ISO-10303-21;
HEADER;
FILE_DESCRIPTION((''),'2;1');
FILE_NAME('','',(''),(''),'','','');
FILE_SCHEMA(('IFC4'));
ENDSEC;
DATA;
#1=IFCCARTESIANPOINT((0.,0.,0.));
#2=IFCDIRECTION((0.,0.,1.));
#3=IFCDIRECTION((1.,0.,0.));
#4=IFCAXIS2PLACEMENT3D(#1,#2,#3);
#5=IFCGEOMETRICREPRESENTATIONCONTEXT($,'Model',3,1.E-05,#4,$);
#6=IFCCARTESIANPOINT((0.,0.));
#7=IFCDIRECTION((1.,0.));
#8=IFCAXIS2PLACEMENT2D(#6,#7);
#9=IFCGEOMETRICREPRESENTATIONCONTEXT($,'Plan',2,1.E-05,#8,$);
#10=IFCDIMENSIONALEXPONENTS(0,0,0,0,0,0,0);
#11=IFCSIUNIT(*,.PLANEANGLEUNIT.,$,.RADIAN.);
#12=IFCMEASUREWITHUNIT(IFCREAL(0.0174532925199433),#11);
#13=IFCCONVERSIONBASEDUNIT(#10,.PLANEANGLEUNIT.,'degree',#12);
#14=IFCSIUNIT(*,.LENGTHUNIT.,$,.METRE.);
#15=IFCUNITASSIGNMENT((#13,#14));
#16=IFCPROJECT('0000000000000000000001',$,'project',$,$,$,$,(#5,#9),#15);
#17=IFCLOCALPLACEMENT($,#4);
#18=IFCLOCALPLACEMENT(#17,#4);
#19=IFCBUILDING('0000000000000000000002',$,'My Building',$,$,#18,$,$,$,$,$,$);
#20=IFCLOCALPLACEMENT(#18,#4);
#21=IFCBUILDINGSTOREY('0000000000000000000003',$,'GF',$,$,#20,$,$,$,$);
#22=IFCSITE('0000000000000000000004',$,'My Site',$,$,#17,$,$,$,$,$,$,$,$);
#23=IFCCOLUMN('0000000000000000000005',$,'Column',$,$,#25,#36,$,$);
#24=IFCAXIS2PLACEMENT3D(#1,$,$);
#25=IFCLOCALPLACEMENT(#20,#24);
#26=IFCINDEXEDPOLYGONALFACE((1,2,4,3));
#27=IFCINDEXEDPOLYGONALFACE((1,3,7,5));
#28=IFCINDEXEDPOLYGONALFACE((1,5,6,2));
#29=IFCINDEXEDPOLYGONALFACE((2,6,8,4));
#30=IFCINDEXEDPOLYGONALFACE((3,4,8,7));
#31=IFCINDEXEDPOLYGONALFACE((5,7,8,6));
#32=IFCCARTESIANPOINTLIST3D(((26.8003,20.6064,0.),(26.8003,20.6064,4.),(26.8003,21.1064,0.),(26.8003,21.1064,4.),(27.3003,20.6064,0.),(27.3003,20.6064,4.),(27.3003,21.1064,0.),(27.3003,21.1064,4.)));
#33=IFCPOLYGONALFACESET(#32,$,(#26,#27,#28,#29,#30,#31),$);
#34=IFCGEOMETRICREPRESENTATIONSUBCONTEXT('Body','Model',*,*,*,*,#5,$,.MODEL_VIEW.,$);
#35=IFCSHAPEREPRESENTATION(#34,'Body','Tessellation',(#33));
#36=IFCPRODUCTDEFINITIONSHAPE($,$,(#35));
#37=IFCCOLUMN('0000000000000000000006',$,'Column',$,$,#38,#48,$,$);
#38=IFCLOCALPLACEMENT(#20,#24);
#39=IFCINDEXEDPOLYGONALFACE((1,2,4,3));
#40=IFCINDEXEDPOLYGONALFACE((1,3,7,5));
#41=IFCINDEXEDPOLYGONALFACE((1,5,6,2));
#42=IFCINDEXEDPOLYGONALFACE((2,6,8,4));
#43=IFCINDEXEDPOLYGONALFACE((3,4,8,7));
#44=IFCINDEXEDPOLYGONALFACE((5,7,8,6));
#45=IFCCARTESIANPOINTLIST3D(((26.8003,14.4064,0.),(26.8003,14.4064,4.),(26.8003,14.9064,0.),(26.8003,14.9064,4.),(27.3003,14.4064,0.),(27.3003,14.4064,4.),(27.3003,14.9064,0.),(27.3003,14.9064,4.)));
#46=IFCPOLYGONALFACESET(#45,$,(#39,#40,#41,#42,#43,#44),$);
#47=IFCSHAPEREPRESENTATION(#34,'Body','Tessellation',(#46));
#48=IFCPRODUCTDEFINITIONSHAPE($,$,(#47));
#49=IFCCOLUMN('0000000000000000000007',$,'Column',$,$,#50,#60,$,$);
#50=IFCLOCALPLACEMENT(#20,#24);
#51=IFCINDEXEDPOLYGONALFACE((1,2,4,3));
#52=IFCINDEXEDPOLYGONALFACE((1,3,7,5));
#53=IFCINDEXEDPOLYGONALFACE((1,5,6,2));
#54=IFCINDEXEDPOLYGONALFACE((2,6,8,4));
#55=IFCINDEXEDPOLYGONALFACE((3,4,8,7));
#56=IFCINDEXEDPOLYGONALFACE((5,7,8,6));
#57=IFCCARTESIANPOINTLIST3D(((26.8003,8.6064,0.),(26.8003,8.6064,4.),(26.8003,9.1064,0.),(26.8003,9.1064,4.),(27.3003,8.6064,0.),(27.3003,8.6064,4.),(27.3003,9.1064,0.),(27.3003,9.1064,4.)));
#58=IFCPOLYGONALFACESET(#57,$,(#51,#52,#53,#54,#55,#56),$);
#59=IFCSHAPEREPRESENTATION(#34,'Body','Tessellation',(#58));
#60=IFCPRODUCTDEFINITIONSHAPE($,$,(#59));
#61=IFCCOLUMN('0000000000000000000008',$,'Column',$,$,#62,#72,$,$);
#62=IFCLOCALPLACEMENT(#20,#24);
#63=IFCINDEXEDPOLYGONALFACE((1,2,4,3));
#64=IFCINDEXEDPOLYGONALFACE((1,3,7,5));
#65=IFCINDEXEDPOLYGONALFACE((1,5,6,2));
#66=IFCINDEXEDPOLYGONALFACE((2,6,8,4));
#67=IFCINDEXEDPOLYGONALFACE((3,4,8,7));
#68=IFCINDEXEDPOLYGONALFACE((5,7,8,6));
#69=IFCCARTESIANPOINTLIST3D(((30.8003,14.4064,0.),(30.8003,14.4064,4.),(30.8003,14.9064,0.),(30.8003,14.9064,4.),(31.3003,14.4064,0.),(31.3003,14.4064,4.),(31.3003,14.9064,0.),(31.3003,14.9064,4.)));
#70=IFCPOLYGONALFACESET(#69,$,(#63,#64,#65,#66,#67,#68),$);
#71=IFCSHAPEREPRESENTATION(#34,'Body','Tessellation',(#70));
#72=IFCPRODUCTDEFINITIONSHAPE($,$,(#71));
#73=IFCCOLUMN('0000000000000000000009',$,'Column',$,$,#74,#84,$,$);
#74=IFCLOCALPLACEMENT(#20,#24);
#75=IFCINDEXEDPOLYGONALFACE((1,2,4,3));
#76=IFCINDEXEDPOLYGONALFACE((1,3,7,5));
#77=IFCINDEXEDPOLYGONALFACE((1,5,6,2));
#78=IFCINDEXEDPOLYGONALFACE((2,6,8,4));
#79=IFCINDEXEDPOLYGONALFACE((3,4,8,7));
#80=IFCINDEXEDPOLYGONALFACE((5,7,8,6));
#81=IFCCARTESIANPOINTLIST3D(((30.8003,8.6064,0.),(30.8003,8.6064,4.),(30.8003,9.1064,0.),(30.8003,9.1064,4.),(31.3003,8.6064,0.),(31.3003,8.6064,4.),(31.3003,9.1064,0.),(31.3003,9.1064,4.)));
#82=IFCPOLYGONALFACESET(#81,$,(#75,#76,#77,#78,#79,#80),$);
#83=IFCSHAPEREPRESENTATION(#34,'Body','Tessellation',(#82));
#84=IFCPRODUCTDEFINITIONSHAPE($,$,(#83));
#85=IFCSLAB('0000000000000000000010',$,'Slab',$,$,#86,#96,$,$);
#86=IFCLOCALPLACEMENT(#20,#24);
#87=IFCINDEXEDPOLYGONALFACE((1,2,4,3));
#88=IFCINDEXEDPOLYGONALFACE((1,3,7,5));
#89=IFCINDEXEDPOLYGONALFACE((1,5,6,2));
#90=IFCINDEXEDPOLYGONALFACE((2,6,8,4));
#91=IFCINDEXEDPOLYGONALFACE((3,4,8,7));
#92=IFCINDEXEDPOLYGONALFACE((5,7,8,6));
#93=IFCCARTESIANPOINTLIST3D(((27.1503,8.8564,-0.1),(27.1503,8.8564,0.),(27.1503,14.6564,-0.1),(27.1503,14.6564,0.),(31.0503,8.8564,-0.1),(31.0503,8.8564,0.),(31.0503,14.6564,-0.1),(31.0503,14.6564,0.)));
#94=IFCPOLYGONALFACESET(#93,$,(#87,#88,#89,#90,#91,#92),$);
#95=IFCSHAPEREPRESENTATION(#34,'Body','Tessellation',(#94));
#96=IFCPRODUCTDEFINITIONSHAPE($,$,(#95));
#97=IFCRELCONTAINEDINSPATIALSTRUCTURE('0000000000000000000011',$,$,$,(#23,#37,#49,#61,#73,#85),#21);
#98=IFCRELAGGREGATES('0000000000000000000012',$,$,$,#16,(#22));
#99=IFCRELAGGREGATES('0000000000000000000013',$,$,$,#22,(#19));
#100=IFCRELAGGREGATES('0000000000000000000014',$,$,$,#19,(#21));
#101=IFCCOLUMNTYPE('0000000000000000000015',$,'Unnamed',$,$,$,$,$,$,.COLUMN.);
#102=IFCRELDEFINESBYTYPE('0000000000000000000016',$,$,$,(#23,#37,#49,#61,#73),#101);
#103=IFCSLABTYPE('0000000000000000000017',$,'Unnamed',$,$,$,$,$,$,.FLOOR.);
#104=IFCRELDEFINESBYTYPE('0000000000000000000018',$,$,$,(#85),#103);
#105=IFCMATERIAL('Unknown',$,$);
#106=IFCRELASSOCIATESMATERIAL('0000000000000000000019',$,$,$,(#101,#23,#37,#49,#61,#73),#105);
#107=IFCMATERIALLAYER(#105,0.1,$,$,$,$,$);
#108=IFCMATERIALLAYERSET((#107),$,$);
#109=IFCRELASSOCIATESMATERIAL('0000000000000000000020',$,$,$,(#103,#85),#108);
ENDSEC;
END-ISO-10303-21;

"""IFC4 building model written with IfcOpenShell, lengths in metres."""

from ifc_helpers import new_model, entity, si_unit, converted_unit, frame, origin_with_axes, origin_2d_with_axis, place, context, subcontext, project, spatial, indexed_curve, rectangle, outline, extrude, material, layer, layer_set, layer_usage, material_profile, profile_set, profile_usage, type_object, element, save


model = new_model("IFC4")

# Units and contexts
model_context = context("Model", 3, precision=1e-05, world=origin_with_axes())
plan_context = context("Plan", 2, precision=1e-05, world=origin_2d_with_axis())
body_context_1 = subcontext(model_context, "Body", "Model", "MODEL_VIEW")
ifc_project = project(units=[converted_unit("PLANEANGLEUNIT", "degree", entity("IfcReal", 0.0174532925199433), si_unit("PLANEANGLEUNIT", "RADIAN"), dimensions=[0, 0, 0, 0, 0, 0, 0]), si_unit("LENGTHUNIT", "METRE")], contexts=[model_context, plan_context])

# Site, building, storey
site_placement = place(None, origin_with_axes())
site = spatial("IfcSite", under=ifc_project, at=site_placement, Name="My Site")
building_placement = place(site_placement, origin_with_axes())
building = spatial("IfcBuilding", under=site, at=building_placement, Name="My Building")
storey_placement = place(building_placement, origin_with_axes())
storey = spatial("IfcBuildingStorey", under=building, at=storey_placement, Name="GF")

# Columns
ifc_material = material(Name="Unknown")
ifc_material_profile_1 = material_profile(ifc_material, rectangle(XDim=0.5, YDim=0.5))
ifc_profile_set_1 = profile_set([ifc_material_profile_1])
ifc_profile_usage_1 = profile_usage(ifc_profile_set_1, cardinal=5)
column_type = type_object("IfcColumnType", Name="Unnamed", PredefinedType="COLUMN", material=ifc_profile_set_1)
column_1_placement = place(storey_placement, frame((27.0503, 20.8564, 0.0), z_axis=(0.0, 0.0, 1.0), x_axis=(1.0, 0.0, 0.0)))
element("IfcColumn", 1, at=column_1_placement, inside=storey, type_object=column_type, material=ifc_profile_usage_1, Name="Column", context=body_context_1, shape_type="SweptSolid", body=[
    extrude(rectangle(XDim=0.5, YDim=0.5), origin_with_axes(), (0.0, 0.0, 1.0), 4.0),
])
ifc_profile_usage_2 = profile_usage(ifc_profile_set_1, cardinal=5)
column_2_placement = place(storey_placement, frame((27.0503, 14.6564, 0.0), z_axis=(0.0, 0.0, 1.0), x_axis=(1.0, 0.0, 0.0)))
element("IfcColumn", 2, at=column_2_placement, inside=storey, type_object=column_type, material=ifc_profile_usage_2, Name="Column", context=body_context_1, shape_type="SweptSolid", body=[
    extrude(rectangle(XDim=0.5, YDim=0.5), origin_with_axes(), (0.0, 0.0, 1.0), 4.0),
])
ifc_profile_usage_3 = profile_usage(ifc_profile_set_1, cardinal=5)
column_3_placement = place(storey_placement, frame((27.0503, 8.8564, 0.0), z_axis=(0.0, 0.0, 1.0), x_axis=(1.0, 0.0, 0.0)))
element("IfcColumn", 3, at=column_3_placement, inside=storey, type_object=column_type, material=ifc_profile_usage_3, Name="Column", context=body_context_1, shape_type="SweptSolid", body=[
    extrude(rectangle(XDim=0.5, YDim=0.5), origin_with_axes(), (0.0, 0.0, 1.0), 4.0),
])
ifc_profile_usage_4 = profile_usage(ifc_profile_set_1, cardinal=5)
column_4_placement = place(storey_placement, frame((31.0503, 14.6564, 0.0), z_axis=(0.0, 0.0, 1.0), x_axis=(1.0, 0.0, 0.0)))
element("IfcColumn", 4, at=column_4_placement, inside=storey, type_object=column_type, material=ifc_profile_usage_4, Name="Column", context=body_context_1, shape_type="SweptSolid", body=[
    extrude(rectangle(XDim=0.5, YDim=0.5), origin_with_axes(), (0.0, 0.0, 1.0), 4.0),
])
ifc_profile_usage_5 = profile_usage(ifc_profile_set_1, cardinal=5)
column_5_placement = place(storey_placement, frame((31.0503, 8.8564, 0.0), z_axis=(0.0, 0.0, 1.0), x_axis=(1.0, 0.0, 0.0)))
element("IfcColumn", 5, at=column_5_placement, inside=storey, type_object=column_type, material=ifc_profile_usage_5, Name="Column", context=body_context_1, shape_type="SweptSolid", body=[
    extrude(rectangle(XDim=0.5, YDim=0.5), origin_with_axes(), (0.0, 0.0, 1.0), 4.0),
])

# Slab
ifc_layer_1 = layer(ifc_material, 0.1)
ifc_layer_set_1 = layer_set([ifc_layer_1])
ifc_layer_usage_1 = layer_usage(ifc_layer_set_1, "AXIS3", "POSITIVE", -0.1)
slab_type = type_object("IfcSlabType", Name="Unnamed", PredefinedType="FLOOR", material=ifc_layer_set_1)
slab_placement = place(storey_placement, frame((27.1503, 14.6564, 0.0), z_axis=(0.0, 0.0, 1.0), x_axis=(1.0, 0.0, 0.0)))
element("IfcSlab", 6, at=slab_placement, inside=storey, type_object=slab_type, material=ifc_layer_usage_1, Name="Slab", context=body_context_1, shape_type="SweptSolid", body=[
    extrude(outline(indexed_curve([(0.0, 0.0), (3.9, 0.0), (3.9, -5.8), (0.0, -5.8), (0.0, 0.0)])), frame((0.0, 0.0, -0.1), z_axis=(0.0, 0.0, 1.0), x_axis=(1.0, 0.0, 0.0)), (0.0, 0.0, 1.0), 0.1),
])

save(model, "model.ifc")
